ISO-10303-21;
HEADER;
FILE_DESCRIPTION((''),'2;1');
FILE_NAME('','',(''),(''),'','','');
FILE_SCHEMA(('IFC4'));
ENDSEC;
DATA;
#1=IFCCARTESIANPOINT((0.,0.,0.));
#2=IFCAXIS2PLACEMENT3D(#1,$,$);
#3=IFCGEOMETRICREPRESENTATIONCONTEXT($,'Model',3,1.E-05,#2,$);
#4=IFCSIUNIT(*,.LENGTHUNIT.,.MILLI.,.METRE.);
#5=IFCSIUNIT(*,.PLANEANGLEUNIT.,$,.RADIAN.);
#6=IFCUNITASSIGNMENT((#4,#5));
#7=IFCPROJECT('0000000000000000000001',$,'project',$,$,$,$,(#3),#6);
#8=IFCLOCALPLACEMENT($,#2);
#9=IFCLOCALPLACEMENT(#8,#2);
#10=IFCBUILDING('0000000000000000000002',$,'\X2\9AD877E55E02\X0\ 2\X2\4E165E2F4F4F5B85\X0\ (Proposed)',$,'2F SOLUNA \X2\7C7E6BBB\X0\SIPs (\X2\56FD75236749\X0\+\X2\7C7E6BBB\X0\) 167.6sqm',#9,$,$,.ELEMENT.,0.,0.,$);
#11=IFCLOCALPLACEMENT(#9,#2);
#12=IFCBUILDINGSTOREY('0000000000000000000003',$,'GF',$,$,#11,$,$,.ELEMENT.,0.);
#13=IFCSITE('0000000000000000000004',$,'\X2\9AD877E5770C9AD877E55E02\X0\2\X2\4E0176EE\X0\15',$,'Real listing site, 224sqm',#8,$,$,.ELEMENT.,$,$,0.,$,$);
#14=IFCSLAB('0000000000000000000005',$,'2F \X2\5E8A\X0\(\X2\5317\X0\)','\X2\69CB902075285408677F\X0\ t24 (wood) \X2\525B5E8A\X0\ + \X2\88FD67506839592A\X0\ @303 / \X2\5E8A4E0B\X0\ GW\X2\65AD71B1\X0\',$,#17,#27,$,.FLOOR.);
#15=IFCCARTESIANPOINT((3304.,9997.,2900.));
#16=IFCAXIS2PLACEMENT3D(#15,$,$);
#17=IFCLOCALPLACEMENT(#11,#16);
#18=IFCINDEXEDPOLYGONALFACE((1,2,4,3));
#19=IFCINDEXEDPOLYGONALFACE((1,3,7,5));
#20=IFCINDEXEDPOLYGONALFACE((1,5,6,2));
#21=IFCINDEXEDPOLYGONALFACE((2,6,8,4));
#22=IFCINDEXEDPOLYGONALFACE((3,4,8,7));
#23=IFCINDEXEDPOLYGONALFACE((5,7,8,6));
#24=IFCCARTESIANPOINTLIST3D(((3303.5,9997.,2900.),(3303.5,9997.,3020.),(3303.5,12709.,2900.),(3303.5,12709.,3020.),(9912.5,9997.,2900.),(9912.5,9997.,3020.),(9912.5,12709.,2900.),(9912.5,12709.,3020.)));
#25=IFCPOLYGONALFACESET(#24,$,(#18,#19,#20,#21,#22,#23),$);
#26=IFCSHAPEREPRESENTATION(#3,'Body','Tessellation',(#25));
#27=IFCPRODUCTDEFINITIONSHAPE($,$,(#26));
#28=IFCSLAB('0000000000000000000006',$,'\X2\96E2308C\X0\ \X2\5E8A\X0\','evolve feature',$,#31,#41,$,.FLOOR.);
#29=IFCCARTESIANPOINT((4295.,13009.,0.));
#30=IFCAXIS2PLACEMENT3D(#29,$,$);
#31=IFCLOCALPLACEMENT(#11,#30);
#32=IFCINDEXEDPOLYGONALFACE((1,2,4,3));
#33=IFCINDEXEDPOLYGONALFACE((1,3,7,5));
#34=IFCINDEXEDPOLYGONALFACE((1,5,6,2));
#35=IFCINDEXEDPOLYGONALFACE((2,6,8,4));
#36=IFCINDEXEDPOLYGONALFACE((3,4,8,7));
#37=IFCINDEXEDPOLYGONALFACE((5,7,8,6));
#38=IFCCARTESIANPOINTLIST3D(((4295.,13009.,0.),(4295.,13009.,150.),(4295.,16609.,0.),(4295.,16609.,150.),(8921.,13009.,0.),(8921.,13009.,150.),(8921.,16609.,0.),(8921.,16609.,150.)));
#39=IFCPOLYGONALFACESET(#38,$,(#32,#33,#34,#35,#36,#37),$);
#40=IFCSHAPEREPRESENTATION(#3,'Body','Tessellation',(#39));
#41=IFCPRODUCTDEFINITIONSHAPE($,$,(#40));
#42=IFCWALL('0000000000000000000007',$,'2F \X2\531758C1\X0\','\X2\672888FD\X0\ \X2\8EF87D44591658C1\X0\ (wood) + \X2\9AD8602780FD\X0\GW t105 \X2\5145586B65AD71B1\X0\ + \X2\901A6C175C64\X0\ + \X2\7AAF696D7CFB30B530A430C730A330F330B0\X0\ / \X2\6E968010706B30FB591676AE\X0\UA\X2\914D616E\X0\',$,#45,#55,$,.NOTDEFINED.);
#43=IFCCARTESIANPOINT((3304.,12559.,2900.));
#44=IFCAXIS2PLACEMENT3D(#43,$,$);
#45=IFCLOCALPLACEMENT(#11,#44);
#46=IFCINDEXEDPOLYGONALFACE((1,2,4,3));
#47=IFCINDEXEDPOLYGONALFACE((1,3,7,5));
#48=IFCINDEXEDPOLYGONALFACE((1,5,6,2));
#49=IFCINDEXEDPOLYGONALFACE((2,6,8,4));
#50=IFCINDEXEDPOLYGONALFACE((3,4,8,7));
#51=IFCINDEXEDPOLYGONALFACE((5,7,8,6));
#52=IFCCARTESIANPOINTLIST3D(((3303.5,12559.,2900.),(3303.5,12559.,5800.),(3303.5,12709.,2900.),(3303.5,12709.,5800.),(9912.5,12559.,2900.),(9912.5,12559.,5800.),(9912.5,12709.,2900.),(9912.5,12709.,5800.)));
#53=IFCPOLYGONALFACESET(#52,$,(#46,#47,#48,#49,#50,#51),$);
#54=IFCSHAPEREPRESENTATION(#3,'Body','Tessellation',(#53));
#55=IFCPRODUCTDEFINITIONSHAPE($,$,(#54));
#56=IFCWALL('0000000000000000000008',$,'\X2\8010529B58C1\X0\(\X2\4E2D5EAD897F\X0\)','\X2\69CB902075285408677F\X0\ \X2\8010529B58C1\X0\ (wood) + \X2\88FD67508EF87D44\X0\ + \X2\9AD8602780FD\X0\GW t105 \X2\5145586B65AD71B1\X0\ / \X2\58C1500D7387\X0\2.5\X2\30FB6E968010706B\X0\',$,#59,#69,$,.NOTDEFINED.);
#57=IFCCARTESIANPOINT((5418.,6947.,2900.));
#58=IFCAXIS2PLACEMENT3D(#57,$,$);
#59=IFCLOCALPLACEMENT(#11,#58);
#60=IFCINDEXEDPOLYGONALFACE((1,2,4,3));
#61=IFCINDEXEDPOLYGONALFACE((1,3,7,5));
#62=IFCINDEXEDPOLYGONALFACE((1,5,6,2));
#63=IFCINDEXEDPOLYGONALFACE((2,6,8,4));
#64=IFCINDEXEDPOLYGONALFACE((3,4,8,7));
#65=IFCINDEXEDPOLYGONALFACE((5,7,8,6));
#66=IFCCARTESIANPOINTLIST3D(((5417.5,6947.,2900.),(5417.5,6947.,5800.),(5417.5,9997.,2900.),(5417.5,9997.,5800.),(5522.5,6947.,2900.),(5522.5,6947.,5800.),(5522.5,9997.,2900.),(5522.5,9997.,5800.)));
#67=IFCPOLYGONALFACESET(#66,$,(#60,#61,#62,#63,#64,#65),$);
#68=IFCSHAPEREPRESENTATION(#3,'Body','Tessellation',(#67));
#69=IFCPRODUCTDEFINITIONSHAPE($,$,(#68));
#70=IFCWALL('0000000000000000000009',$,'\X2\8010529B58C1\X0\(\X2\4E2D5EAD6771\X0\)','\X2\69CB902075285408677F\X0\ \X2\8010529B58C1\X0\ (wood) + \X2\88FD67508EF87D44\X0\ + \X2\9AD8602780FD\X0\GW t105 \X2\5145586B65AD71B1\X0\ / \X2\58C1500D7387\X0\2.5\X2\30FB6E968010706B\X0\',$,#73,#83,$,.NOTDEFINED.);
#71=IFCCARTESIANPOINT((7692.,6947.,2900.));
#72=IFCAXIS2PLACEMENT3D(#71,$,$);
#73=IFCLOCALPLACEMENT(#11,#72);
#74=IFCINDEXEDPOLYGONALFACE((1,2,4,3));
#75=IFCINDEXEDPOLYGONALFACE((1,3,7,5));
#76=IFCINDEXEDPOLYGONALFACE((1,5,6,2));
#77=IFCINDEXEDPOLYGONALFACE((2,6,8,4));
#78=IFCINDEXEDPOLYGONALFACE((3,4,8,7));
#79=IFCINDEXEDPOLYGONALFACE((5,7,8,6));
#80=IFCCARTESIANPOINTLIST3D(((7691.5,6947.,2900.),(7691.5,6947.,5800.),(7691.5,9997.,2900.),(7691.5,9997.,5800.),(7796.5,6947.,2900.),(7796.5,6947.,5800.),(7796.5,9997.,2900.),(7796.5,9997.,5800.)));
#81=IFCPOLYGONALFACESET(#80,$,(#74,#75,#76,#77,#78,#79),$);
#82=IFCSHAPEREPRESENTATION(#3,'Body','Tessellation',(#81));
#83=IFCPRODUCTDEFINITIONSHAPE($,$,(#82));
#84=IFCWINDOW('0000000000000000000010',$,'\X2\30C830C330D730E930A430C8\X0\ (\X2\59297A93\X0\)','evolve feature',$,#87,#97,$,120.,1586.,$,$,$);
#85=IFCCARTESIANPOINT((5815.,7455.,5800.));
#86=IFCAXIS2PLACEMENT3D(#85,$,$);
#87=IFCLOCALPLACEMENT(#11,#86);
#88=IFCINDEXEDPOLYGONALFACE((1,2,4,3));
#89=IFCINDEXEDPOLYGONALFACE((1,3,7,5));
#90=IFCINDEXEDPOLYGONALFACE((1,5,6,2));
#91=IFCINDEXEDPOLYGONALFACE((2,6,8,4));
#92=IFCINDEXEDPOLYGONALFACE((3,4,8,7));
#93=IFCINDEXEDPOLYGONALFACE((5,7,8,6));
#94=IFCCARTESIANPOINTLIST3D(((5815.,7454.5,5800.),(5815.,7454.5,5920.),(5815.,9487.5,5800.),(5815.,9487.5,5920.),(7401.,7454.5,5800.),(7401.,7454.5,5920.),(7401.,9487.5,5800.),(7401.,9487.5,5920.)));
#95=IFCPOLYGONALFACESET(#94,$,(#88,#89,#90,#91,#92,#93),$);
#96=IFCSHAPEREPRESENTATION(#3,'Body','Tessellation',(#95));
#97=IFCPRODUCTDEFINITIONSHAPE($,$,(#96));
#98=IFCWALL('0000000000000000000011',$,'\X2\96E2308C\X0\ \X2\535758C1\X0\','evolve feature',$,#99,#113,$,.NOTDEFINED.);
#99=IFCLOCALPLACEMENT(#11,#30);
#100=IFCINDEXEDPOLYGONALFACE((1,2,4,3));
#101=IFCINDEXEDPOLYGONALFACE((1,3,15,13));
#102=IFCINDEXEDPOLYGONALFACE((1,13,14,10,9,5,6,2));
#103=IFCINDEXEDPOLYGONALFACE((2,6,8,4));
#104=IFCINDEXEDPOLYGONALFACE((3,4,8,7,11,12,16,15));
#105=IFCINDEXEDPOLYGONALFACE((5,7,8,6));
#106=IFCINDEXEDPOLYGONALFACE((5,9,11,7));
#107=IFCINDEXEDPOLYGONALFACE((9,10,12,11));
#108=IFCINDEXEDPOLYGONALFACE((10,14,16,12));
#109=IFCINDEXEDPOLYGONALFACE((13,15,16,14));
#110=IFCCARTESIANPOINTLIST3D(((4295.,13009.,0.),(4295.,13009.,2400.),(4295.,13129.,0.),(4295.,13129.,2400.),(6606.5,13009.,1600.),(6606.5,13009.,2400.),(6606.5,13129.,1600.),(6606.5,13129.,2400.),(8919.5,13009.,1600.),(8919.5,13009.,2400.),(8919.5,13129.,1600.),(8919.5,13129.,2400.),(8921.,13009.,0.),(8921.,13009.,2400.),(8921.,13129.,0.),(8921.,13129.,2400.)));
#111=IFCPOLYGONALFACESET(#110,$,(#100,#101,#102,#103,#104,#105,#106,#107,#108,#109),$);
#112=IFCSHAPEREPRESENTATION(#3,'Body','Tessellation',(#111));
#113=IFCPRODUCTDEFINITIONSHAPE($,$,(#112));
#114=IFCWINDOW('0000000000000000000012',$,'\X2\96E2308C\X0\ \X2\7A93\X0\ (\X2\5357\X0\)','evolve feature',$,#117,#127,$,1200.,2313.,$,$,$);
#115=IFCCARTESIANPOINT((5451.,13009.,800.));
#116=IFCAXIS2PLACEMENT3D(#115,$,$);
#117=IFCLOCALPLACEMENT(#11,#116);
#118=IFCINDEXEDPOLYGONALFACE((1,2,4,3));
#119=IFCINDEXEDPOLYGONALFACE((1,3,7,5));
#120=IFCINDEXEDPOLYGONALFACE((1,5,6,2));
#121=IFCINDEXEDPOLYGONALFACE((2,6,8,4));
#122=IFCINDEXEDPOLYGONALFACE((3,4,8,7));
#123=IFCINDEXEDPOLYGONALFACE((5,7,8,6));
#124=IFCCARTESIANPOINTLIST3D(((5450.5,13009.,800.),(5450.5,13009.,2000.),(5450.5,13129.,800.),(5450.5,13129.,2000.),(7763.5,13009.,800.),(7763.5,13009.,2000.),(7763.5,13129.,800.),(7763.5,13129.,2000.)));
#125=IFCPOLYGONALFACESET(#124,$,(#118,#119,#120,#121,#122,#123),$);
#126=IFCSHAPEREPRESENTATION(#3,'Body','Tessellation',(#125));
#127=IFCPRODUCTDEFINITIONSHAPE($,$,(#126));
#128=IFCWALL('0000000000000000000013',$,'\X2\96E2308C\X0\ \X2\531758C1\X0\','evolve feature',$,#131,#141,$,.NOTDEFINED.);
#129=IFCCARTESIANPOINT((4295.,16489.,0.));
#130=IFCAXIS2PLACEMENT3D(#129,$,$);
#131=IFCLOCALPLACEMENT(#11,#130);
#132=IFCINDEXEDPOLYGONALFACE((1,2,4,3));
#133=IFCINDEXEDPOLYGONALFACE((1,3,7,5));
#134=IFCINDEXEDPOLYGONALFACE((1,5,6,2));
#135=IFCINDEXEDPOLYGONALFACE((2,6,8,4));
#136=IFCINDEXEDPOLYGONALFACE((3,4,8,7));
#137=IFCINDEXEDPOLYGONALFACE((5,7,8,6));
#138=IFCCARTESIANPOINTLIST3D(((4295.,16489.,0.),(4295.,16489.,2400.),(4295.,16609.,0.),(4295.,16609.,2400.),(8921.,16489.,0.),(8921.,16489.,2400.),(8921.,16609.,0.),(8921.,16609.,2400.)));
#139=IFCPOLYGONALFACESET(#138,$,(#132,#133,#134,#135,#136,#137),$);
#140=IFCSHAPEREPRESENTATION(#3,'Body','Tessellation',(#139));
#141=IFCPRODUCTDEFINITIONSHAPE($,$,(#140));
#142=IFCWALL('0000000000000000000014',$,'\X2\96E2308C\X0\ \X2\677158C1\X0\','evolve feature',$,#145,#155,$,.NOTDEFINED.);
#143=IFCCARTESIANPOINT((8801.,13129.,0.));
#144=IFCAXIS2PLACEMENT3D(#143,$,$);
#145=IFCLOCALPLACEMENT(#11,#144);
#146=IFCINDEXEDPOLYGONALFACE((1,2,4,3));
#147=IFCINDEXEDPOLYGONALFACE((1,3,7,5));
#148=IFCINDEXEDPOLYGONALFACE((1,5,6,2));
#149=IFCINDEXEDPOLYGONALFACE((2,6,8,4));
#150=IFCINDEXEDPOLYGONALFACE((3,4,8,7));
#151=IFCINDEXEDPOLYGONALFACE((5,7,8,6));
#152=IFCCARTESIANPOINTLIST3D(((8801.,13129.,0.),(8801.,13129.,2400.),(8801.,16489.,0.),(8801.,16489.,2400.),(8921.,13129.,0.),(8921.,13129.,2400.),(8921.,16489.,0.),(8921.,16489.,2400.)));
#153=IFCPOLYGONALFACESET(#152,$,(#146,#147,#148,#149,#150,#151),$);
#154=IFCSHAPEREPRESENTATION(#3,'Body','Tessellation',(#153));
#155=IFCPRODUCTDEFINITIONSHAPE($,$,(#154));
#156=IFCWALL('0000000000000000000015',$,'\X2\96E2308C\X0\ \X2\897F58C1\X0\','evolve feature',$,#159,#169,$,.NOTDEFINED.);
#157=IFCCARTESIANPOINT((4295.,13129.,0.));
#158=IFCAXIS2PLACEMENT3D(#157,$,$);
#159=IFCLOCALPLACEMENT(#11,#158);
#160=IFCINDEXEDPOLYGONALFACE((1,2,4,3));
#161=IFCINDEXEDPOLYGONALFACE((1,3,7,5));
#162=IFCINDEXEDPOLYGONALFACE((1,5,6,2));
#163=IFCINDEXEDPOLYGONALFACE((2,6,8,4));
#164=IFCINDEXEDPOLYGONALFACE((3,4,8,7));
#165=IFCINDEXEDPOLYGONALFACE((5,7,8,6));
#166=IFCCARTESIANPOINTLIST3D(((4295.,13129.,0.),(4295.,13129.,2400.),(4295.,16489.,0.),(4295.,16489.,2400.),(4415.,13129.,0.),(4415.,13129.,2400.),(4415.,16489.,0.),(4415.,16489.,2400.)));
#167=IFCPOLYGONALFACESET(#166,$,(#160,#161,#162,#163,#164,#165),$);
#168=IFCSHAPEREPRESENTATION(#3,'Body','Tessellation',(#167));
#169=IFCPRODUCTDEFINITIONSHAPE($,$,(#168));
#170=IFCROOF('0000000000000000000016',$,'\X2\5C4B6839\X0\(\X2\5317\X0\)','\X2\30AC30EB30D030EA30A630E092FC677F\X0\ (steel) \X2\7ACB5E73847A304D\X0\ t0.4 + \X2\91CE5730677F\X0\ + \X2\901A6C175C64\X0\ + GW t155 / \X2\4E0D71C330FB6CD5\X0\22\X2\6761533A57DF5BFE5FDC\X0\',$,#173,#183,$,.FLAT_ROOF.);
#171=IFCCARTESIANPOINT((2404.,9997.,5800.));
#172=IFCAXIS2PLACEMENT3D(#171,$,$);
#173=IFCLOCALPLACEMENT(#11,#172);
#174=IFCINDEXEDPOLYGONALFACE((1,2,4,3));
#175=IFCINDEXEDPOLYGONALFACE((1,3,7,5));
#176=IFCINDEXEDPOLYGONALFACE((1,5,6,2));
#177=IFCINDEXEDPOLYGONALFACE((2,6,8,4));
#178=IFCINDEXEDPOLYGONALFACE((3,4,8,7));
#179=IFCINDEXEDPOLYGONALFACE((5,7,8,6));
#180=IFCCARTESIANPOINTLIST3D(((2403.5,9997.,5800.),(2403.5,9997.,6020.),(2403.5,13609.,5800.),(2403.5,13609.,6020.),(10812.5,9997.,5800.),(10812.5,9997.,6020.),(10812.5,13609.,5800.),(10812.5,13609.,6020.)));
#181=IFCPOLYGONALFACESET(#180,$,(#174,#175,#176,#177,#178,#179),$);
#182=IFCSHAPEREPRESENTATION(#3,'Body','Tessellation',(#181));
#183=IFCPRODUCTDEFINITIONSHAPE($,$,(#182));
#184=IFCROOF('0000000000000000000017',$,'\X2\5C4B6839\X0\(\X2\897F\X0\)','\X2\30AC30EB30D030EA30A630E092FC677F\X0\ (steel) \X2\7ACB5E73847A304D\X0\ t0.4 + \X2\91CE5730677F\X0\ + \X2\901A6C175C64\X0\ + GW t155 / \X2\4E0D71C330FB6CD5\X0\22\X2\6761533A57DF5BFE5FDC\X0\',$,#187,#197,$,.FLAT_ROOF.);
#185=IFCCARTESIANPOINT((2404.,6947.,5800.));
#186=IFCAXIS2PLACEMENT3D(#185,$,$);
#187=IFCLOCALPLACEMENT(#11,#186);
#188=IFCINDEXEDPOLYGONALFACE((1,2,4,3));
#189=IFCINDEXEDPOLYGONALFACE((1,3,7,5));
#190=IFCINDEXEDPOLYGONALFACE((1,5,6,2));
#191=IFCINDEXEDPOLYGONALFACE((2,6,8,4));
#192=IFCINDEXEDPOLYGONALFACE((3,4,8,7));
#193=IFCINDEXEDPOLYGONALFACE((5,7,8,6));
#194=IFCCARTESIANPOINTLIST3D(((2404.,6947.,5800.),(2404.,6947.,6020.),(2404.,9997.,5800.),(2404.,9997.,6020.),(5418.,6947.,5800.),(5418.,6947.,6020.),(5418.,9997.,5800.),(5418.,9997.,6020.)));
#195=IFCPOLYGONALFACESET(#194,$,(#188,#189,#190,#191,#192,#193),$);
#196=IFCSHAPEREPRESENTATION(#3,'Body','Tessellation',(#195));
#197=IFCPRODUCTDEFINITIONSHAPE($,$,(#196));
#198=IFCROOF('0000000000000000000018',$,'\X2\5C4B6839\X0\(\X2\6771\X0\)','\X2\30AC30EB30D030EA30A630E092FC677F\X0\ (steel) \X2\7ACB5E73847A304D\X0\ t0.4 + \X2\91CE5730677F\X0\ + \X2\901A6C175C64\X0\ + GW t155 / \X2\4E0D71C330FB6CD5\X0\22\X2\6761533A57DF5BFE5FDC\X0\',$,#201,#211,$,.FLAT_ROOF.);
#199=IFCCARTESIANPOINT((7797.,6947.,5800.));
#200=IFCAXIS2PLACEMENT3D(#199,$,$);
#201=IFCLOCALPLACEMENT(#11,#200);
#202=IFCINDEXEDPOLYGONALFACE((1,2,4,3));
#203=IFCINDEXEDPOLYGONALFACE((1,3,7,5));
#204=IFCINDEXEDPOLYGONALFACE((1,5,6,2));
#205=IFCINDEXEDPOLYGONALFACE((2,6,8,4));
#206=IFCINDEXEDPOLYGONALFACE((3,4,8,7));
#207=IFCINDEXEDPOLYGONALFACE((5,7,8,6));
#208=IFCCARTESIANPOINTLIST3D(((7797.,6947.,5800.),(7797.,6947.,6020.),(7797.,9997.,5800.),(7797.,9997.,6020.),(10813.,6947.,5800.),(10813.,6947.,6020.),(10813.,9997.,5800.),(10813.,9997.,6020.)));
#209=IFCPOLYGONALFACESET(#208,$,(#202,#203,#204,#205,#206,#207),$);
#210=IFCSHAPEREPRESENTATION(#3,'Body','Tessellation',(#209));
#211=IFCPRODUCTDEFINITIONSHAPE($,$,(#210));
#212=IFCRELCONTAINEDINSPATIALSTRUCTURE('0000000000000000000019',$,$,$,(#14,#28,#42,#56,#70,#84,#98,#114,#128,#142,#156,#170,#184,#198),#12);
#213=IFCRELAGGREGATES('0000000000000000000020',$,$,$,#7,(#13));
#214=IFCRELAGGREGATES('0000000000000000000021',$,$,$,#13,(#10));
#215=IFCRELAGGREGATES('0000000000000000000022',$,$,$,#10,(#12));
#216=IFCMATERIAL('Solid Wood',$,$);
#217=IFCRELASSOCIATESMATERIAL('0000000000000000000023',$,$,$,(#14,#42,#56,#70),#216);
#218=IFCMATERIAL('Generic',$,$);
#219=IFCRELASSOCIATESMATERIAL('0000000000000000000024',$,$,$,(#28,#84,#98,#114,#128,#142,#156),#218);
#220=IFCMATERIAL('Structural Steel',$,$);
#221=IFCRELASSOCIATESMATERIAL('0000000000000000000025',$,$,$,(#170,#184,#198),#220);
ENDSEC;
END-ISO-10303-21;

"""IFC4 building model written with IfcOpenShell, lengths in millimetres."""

from ifc_helpers import new_model, si_unit, frame, frame_2d, origin, place, context, project, spatial, rectangle, extrude, material, element, fill, save


model = new_model("IFC4")

# Units and contexts
model_context = context("Model", 3, precision=1e-05, world=origin())
ifc_project = project(units=[si_unit("LENGTHUNIT", "METRE", prefix="MILLI"), si_unit("PLANEANGLEUNIT", "RADIAN")], contexts=[model_context])

# Site, building, storey
site_placement = place(None, origin())
site = spatial("IfcSite", under=ifc_project, at=site_placement, Name="高知県高知市2丁目15", ObjectType="Real listing site, 224sqm", CompositionType="ELEMENT", RefElevation=0.0)
building_placement = place(site_placement, origin())
building = spatial("IfcBuilding", under=site, at=building_placement, Name="高知市 2世帯住宅 (Proposed)", ObjectType="2F SOLUNA 籾殻SIPs (国産杉+籾殻) 167.6sqm", CompositionType="ELEMENT", ElevationOfRefHeight=0.0, ElevationOfTerrain=0.0)
storey_placement = place(building_placement, origin())
storey = spatial("IfcBuildingStorey", under=building, at=storey_placement, Name="GF", CompositionType="ELEMENT", Elevation=0.0)

# Slabs
ifc_material_1 = material(Name="Solid Wood")
slab_1_placement = place(storey_placement, frame((3304.0, 9997.0, 2900.0)))
element("IfcSlab", 1, at=slab_1_placement, inside=storey, material=ifc_material_1, Name="2F 床(北)", Description="構造用合板 t24 (wood) 剛床 + 製材根太 @303 / 床下 GW断熱", PredefinedType="FLOOR", context=model_context, shape_type="SweptSolid", body=[
    extrude(rectangle(XDim=6609.0, YDim=2712.0, at=frame_2d((3304.0, 1356.0))), frame((3304.0, 9997.0, 2900.0)), (0.0, 0.0, 1.0), 120.0),
])
ifc_material_2 = material(Name="Generic")
slab_2_placement = place(storey_placement, frame((4295.0, 13009.0, 0.0)))
element("IfcSlab", 2, at=slab_2_placement, inside=storey, material=ifc_material_2, Name="離れ 床", Description="evolve feature", PredefinedType="FLOOR", context=model_context, shape_type="SweptSolid", body=[
    extrude(rectangle(XDim=4626.0, YDim=3600.0, at=frame_2d((2313.0, 1800.0))), frame((4295.0, 13009.0, 0.0)), (0.0, 0.0, 1.0), 150.0),
])

# Wall
wall_1_placement = place(storey_placement, frame((3304.0, 12559.0, 2900.0)))
element("IfcWall", 3, at=wall_1_placement, inside=storey, material=ifc_material_1, Name="2F 北壁", Description="木製 軸組外壁 (wood) + 高性能GW t105 充填断熱 + 通気層 + 窯業系サイディング / 準耐火・外皮UA配慮", PredefinedType="NOTDEFINED", context=model_context, shape_type="SweptSolid", body=[
    extrude(rectangle(XDim=6609.0, YDim=150.0, at=frame_2d((3304.0, 75.0))), frame((3304.0, 12559.0, 2900.0)), (0.0, 0.0, 1.0), 2900.0),
])

# Walls
wall_2_placement = place(storey_placement, frame((5418.0, 6947.0, 2900.0)))
element("IfcWall", 4, at=wall_2_placement, inside=storey, material=ifc_material_1, Name="耐力壁(中庭西)", Description="構造用合板 耐力壁 (wood) + 製材軸組 + 高性能GW t105 充填断熱 / 壁倍率2.5・準耐火", PredefinedType="NOTDEFINED", context=model_context, shape_type="SweptSolid", body=[
    extrude(rectangle(XDim=105.0, YDim=3050.0, at=frame_2d((52.0, 1525.0))), frame((5418.0, 6947.0, 2900.0)), (0.0, 0.0, 1.0), 2900.0),
])
wall_3_placement = place(storey_placement, frame((7692.0, 6947.0, 2900.0)))
element("IfcWall", 5, at=wall_3_placement, inside=storey, material=ifc_material_1, Name="耐力壁(中庭東)", Description="構造用合板 耐力壁 (wood) + 製材軸組 + 高性能GW t105 充填断熱 / 壁倍率2.5・準耐火", PredefinedType="NOTDEFINED", context=model_context, shape_type="SweptSolid", body=[
    extrude(rectangle(XDim=105.0, YDim=3050.0, at=frame_2d((52.0, 1525.0))), frame((7692.0, 6947.0, 2900.0)), (0.0, 0.0, 1.0), 2900.0),
])

# Window
window_1_placement = place(storey_placement, frame((5815.0, 7455.0, 5800.0)))
element("IfcWindow", 6, at=window_1_placement, inside=storey, material=ifc_material_2, Name="トップライト (天窓)", Description="evolve feature", OverallHeight=120.0, OverallWidth=1586.0, context=model_context, shape_type="SweptSolid", body=[
    extrude(rectangle(XDim=1586.0, YDim=2033.0, at=frame_2d((793.0, 1016.0))), frame((5815.0, 7455.0, 5800.0)), (0.0, 0.0, 1.0), 120.0),
])

# Wall, opening, window
wall_4_placement = place(storey_placement, frame((4295.0, 13009.0, 0.0)))
wall_4 = element("IfcWall", 7, at=wall_4_placement, inside=storey, material=ifc_material_2, Name="離れ 南壁", Description="evolve feature", PredefinedType="NOTDEFINED", context=model_context, shape_type="SweptSolid", body=[
    extrude(rectangle(XDim=4626.0, YDim=120.0, at=frame_2d((2313.0, 60.0))), frame((4295.0, 13009.0, 0.0)), (0.0, 0.0, 1.0), 2400.0),
])
opening_1_placement = place(storey_placement, frame((5451.0, 13009.0, 800.0)))
opening_1 = element("IfcOpeningElement", 8, at=opening_1_placement, cuts=wall_4, PredefinedType="NOTDEFINED", context=model_context, shape_type="SweptSolid", body=[
    extrude(rectangle(XDim=2313.0, YDim=120.0, at=frame_2d((1156.0, 60.0))), frame((5451.0, 13009.0, 800.0)), (0.0, 0.0, 1.0), 1200.0),
])
window_2_placement = place(storey_placement, frame((5451.0, 13009.0, 800.0)))
window_2 = element("IfcWindow", 9, at=window_2_placement, inside=storey, material=ifc_material_2, Name="離れ 窓 (南)", Description="evolve feature", OverallHeight=1200.0, OverallWidth=2313.0, context=model_context, shape_type="SweptSolid", body=[
    extrude(rectangle(XDim=2313.0, YDim=120.0, at=frame_2d((1156.0, 60.0))), frame((5451.0, 13009.0, 800.0)), (0.0, 0.0, 1.0), 1200.0),
])
fill(opening_1, window_2)

# Walls
wall_5_placement = place(storey_placement, frame((4295.0, 16489.0, 0.0)))
element("IfcWall", 10, at=wall_5_placement, inside=storey, material=ifc_material_2, Name="離れ 北壁", Description="evolve feature", PredefinedType="NOTDEFINED", context=model_context, shape_type="SweptSolid", body=[
    extrude(rectangle(XDim=4626.0, YDim=120.0, at=frame_2d((2313.0, 60.0))), frame((4295.0, 16489.0, 0.0)), (0.0, 0.0, 1.0), 2400.0),
])
wall_6_placement = place(storey_placement, frame((8801.0, 13129.0, 0.0)))
element("IfcWall", 11, at=wall_6_placement, inside=storey, material=ifc_material_2, Name="離れ 東壁", Description="evolve feature", PredefinedType="NOTDEFINED", context=model_context, shape_type="SweptSolid", body=[
    extrude(rectangle(XDim=120.0, YDim=3360.0, at=frame_2d((60.0, 1680.0))), frame((8801.0, 13129.0, 0.0)), (0.0, 0.0, 1.0), 2400.0),
])
wall_7_placement = place(storey_placement, frame((4295.0, 13129.0, 0.0)))
element("IfcWall", 12, at=wall_7_placement, inside=storey, material=ifc_material_2, Name="離れ 西壁", Description="evolve feature", PredefinedType="NOTDEFINED", context=model_context, shape_type="SweptSolid", body=[
    extrude(rectangle(XDim=120.0, YDim=3360.0, at=frame_2d((60.0, 1680.0))), frame((4295.0, 13129.0, 0.0)), (0.0, 0.0, 1.0), 2400.0),
])

# Roofs
ifc_material_3 = material(Name="Structural Steel")
for number, where, name in (
    (13, (2404.0, 9997.0, 5800.0), "屋根(北)"),
):
    element("IfcRoof", number, at=place(storey_placement, frame(where)), inside=storey, material=ifc_material_3, Name=name, Description="ガルバリウム鋼板 (steel) 立平葺き t0.4 + 野地板 + 通気層 + GW t155 / 不燃・法22条区域対応", PredefinedType="FLAT_ROOF", context=model_context, shape_type="SweptSolid", body=[
        extrude(rectangle(XDim=8409.0, YDim=3612.0, at=frame_2d((4204.0, 1806.0))), frame((2404.0, 9997.0, 5800.0)), (0.0, 0.0, 1.0), 220.0),
    ])
roof_1_placement = place(storey_placement, frame((2404.0, 6947.0, 5800.0)))
element("IfcRoof", 14, at=roof_1_placement, inside=storey, material=ifc_material_3, Name="屋根(西)", Description="ガルバリウム鋼板 (steel) 立平葺き t0.4 + 野地板 + 通気層 + GW t155 / 不燃・法22条区域対応", PredefinedType="FLAT_ROOF", context=model_context, shape_type="SweptSolid", body=[
    extrude(rectangle(XDim=3014.0, YDim=3050.0, at=frame_2d((1507.0, 1525.0))), frame((2404.0, 6947.0, 5800.0)), (0.0, 0.0, 1.0), 220.0),
])
roof_2_placement = place(storey_placement, frame((7797.0, 6947.0, 5800.0)))
element("IfcRoof", 15, at=roof_2_placement, inside=storey, material=ifc_material_3, Name="屋根(東)", Description="ガルバリウム鋼板 (steel) 立平葺き t0.4 + 野地板 + 通気層 + GW t155 / 不燃・法22条区域対応", PredefinedType="FLAT_ROOF", context=model_context, shape_type="SweptSolid", body=[
    extrude(rectangle(XDim=3016.0, YDim=3050.0, at=frame_2d((1508.0, 1525.0))), frame((7797.0, 6947.0, 5800.0)), (0.0, 0.0, 1.0), 220.0),
])

save(model, "model.ifc")
